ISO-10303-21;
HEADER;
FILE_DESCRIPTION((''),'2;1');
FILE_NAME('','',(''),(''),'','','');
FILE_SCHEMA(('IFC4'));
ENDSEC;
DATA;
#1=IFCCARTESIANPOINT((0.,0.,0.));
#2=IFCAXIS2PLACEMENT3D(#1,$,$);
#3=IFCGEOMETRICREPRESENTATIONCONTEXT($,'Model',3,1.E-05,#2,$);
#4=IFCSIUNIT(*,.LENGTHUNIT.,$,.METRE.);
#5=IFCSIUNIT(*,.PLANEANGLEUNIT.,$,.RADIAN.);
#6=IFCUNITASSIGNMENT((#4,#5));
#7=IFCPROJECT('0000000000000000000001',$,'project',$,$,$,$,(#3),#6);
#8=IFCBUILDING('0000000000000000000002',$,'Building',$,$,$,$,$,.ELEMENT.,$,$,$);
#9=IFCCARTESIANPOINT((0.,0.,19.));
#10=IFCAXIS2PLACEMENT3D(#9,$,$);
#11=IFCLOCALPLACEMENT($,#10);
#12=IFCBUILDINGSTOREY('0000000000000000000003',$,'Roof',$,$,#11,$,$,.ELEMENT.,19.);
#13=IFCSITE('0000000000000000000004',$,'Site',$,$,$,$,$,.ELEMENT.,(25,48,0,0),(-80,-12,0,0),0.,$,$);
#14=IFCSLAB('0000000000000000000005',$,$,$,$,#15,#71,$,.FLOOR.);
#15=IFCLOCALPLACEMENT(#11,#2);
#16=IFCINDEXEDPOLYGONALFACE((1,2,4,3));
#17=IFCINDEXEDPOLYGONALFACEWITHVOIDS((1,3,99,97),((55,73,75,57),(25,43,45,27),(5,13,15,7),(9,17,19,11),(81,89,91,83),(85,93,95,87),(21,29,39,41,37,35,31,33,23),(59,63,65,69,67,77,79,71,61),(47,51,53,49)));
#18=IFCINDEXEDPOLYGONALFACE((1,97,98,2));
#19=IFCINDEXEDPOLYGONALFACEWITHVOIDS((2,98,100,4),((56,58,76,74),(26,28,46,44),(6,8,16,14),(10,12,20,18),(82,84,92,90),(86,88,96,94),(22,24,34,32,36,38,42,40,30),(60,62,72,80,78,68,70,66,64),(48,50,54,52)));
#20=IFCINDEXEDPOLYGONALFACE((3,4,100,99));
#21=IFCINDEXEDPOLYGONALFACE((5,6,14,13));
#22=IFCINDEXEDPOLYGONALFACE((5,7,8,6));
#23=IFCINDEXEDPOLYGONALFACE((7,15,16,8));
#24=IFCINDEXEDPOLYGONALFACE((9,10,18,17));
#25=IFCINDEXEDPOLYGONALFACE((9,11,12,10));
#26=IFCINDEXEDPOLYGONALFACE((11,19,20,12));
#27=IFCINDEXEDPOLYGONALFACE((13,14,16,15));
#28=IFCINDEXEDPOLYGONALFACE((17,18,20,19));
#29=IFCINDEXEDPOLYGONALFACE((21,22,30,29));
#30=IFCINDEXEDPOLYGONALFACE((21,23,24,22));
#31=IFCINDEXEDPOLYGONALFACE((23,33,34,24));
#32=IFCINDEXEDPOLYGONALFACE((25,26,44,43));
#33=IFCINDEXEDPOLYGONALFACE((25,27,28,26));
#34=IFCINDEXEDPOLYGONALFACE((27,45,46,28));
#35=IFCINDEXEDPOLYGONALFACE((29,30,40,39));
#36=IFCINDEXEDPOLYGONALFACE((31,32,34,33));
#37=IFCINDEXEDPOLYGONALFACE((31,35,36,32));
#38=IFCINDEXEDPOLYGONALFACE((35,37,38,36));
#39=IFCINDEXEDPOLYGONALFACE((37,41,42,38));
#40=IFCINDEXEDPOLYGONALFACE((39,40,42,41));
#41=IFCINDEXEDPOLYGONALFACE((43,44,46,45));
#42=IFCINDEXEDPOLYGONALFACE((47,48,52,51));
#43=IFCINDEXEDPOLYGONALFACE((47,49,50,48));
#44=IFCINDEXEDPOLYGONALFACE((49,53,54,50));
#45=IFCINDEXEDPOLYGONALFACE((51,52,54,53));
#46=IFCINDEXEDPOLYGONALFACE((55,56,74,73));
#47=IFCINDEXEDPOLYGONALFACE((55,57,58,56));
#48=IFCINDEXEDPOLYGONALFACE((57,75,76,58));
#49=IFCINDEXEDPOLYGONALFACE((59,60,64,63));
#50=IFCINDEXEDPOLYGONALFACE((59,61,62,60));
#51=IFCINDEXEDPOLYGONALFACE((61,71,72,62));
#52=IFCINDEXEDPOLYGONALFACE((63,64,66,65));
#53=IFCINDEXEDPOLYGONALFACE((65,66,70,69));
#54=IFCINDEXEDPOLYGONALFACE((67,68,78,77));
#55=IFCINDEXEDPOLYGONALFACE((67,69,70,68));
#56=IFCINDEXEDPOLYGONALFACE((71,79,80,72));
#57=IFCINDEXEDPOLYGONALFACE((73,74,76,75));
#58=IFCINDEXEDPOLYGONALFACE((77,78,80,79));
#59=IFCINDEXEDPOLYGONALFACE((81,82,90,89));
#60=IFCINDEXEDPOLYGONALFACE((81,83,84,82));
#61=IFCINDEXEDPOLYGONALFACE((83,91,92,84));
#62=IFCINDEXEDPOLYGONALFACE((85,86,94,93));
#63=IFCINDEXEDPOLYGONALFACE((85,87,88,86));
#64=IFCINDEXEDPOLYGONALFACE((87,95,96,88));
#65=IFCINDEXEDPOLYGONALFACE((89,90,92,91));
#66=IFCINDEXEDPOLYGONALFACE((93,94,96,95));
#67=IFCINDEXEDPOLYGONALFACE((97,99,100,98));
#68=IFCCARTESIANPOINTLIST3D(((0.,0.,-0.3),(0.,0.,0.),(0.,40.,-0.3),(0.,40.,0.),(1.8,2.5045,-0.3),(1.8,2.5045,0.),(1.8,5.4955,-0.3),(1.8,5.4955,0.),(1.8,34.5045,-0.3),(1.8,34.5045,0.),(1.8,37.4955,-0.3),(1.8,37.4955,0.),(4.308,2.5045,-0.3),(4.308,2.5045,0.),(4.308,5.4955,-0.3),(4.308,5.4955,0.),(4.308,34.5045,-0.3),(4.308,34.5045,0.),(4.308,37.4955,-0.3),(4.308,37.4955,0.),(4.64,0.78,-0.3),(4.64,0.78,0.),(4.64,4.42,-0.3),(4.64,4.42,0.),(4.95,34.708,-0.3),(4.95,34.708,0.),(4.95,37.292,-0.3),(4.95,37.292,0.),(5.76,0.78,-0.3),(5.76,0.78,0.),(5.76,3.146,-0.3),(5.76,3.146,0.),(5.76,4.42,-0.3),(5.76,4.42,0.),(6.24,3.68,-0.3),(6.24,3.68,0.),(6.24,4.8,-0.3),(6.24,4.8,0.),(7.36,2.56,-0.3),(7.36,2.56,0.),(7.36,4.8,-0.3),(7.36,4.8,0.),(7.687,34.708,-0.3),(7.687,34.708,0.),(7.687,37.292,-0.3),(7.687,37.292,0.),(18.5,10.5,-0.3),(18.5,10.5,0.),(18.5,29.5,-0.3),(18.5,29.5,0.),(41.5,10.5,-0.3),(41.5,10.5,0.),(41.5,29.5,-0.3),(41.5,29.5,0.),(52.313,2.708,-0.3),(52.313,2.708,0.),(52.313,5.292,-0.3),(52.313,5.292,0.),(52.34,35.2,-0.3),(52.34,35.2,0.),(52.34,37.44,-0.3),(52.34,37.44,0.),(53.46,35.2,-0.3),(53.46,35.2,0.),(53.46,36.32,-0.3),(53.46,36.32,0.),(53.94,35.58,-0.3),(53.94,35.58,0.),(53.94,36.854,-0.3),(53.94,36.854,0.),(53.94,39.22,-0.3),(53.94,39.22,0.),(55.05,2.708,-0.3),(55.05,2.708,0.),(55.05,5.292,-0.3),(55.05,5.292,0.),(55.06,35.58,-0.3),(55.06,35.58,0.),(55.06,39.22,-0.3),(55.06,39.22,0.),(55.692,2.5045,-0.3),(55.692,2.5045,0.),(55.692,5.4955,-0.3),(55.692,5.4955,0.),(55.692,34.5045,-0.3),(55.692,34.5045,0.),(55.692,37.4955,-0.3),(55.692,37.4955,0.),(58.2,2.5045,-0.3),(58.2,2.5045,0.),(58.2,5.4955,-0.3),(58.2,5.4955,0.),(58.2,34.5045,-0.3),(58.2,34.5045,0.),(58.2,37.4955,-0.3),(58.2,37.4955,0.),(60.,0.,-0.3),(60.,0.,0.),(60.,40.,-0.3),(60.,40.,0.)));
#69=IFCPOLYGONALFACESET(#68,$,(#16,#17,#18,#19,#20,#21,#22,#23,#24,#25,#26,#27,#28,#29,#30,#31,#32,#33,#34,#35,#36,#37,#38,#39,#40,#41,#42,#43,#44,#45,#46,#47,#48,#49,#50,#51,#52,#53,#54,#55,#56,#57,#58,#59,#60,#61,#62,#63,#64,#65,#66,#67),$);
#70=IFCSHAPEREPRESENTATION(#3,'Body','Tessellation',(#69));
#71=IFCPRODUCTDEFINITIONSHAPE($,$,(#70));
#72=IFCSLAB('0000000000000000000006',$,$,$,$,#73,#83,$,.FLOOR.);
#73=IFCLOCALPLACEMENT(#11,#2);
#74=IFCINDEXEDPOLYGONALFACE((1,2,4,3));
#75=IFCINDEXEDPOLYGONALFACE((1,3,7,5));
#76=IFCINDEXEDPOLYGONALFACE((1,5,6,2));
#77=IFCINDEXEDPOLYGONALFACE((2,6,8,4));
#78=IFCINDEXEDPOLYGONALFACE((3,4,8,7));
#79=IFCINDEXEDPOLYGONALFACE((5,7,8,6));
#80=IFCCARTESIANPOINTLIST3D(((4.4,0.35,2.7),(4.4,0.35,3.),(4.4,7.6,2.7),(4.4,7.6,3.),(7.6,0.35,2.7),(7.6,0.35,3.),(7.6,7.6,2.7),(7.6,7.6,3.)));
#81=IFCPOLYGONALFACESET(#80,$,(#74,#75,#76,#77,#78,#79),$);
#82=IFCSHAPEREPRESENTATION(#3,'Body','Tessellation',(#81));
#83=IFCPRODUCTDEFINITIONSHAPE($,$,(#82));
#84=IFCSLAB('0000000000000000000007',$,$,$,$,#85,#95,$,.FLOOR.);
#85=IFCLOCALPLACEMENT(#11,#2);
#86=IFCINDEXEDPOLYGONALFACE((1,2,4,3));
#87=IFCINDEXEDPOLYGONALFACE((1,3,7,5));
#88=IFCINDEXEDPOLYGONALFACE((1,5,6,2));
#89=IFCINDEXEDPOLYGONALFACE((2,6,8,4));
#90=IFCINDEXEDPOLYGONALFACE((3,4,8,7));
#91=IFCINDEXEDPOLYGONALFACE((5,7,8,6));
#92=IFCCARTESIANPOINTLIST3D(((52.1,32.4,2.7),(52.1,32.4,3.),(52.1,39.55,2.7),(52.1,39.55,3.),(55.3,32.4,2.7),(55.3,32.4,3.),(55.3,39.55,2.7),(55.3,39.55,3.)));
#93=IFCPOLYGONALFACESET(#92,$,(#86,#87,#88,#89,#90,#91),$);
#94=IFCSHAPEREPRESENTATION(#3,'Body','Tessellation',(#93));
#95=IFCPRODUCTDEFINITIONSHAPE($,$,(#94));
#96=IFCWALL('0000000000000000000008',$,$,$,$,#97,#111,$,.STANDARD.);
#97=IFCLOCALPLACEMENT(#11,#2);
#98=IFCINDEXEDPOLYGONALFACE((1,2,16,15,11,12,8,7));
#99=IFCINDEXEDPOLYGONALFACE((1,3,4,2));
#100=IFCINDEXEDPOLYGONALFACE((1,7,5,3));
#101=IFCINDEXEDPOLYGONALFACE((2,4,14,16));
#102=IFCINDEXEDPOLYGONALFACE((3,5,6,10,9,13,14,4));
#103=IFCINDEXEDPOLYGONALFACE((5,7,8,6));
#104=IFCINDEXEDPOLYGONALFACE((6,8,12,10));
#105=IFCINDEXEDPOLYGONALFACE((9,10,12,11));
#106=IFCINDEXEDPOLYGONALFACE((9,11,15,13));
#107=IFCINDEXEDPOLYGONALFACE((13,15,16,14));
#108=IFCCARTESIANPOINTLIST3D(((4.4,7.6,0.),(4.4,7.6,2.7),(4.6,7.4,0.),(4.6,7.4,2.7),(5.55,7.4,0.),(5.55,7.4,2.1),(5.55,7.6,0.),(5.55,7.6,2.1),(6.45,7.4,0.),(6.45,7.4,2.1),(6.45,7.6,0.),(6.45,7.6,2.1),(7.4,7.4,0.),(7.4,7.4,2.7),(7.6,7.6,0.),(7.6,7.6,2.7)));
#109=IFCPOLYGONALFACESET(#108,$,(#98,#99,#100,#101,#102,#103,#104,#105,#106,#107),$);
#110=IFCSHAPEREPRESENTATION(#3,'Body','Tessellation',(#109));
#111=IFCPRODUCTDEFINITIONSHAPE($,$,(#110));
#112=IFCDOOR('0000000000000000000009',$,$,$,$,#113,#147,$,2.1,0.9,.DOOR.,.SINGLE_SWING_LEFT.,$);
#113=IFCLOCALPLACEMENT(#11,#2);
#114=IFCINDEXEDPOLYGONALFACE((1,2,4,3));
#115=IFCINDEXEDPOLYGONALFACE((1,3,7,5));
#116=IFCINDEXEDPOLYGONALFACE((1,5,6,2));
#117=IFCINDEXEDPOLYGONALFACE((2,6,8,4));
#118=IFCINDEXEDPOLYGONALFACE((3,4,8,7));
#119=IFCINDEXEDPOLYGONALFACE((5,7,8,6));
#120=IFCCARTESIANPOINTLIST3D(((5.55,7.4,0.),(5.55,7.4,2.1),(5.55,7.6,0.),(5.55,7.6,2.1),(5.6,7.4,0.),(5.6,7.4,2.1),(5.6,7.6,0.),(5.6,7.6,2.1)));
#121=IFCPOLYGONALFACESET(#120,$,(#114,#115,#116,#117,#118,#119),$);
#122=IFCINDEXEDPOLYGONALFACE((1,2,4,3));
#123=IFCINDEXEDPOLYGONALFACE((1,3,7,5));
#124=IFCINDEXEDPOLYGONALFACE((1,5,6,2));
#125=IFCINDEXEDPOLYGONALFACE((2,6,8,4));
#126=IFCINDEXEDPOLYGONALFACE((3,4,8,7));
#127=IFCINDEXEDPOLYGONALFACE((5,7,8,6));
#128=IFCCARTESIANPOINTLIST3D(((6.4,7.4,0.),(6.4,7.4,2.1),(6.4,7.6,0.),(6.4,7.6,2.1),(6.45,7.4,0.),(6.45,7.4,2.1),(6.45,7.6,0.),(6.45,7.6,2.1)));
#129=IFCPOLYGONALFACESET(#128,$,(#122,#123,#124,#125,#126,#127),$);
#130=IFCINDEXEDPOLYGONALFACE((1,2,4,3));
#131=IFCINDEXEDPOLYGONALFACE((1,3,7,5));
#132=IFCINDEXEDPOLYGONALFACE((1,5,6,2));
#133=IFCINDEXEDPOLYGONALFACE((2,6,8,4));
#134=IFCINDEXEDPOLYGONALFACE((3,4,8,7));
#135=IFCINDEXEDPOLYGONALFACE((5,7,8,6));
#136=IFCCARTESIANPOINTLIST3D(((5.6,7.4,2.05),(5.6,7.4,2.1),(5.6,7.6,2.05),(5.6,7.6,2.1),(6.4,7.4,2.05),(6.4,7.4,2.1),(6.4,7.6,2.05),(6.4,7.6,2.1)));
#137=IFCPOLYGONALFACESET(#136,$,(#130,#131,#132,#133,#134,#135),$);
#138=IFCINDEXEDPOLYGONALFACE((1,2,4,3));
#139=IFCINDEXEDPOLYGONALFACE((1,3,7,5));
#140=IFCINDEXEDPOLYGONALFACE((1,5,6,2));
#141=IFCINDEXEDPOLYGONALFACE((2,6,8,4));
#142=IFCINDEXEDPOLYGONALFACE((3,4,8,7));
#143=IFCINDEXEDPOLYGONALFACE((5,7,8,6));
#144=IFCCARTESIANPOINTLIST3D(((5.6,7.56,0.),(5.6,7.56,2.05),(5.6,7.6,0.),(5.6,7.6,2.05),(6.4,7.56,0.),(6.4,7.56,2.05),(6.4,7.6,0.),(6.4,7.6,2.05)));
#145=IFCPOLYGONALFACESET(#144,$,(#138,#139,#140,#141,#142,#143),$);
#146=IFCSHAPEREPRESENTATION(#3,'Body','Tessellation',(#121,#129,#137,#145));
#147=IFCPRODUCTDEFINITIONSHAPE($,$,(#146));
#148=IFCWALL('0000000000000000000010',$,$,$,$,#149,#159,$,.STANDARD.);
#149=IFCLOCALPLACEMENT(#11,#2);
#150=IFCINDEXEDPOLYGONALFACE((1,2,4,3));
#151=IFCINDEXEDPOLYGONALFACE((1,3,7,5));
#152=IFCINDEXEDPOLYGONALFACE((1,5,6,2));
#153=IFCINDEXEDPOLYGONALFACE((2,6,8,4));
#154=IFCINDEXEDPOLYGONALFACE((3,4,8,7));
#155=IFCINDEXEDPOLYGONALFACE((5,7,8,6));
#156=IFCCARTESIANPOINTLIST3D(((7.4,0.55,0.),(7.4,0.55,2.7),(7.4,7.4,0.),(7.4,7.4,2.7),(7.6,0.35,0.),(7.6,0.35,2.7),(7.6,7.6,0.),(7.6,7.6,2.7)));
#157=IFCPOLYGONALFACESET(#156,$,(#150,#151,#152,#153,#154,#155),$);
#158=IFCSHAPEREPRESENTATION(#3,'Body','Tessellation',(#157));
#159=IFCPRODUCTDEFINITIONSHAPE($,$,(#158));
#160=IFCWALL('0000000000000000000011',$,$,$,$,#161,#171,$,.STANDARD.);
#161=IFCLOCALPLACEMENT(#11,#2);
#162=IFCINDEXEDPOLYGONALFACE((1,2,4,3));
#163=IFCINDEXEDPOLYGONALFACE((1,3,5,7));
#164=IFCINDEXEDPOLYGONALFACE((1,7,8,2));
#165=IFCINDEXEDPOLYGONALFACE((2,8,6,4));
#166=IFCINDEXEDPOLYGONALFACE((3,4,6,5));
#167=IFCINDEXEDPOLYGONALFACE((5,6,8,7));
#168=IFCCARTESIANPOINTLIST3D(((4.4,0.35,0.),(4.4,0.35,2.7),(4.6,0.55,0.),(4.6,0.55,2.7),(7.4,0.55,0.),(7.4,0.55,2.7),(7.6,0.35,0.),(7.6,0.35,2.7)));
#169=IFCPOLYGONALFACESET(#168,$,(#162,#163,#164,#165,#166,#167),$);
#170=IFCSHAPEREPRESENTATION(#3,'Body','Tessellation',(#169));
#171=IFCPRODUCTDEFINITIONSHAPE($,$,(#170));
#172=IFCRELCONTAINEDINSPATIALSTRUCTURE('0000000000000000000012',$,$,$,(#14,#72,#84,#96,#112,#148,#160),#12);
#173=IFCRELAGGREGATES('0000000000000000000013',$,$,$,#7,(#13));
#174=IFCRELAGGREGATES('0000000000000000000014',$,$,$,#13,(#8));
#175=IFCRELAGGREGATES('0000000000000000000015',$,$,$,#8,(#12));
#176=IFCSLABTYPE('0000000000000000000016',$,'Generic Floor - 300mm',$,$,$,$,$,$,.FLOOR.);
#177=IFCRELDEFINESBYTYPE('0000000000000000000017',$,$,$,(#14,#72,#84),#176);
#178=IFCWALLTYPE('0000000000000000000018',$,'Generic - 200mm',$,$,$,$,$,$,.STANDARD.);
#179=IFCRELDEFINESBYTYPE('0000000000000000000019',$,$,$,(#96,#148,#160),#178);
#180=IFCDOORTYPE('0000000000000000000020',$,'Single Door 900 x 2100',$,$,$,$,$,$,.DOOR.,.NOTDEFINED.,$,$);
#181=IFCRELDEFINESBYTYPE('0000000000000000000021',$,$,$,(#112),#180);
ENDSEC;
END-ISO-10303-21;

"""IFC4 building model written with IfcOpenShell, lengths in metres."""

from ifc_helpers import new_model, si_unit, frame, frame_2d, origin, origin_with_axes, origin_2d, place, context, project, spatial, polyline, rectangle, outline, extrude, type_object, element, fill, save


model = new_model("IFC4")

# Units and contexts
model_context = context("Model", 3, precision=1e-05, world=origin())
ifc_project = project(units=[si_unit("LENGTHUNIT", "METRE"), si_unit("PLANEANGLEUNIT", "RADIAN")], contexts=[model_context])

# Site, building, storey
site = spatial("IfcSite", under=ifc_project, Name="Site", CompositionType="ELEMENT", RefLatitude=(25, 48, 0, 0), RefLongitude=(-80, -12, 0, 0), RefElevation=0.0)
building = spatial("IfcBuilding", under=site, Name="Building", CompositionType="ELEMENT")
storey_placement = place(None, frame((0.0, 0.0, 19.0)))
storey = spatial("IfcBuildingStorey", under=building, at=storey_placement, Name="Roof", CompositionType="ELEMENT", Elevation=19.0)

# Slab, openings
slab_type = type_object("IfcSlabType", Name="Generic Floor - 300mm", PredefinedType="FLOOR")
slab_1_placement = place(None, frame((0.0, 0.0, 19.0)))
slab_1 = element("IfcSlab", 1, at=slab_1_placement, inside=storey, type_object=slab_type, PredefinedType="FLOOR", context=model_context, shape_type="SweptSolid", body=[
    extrude(outline(polyline([(0.0, 0.0), (60.0, 0.0), (60.0, 40.0), (0.0, 40.0), (0.0, 0.0)])), origin(), (0.0, 0.0, -1.0), 0.3),
])
opening_1_placement = place(None, frame((0.0, 0.0, 19.001)))
element("IfcOpeningElement", 2, at=opening_1_placement, cuts=slab_1, PredefinedType="OPENING", context=model_context, shape_type="SweptSolid", body=[
    extrude(outline(polyline([(4.64, 0.78), (5.76, 0.78), (7.36, 2.56), (7.36, 4.8), (6.24, 4.8), (6.24, 3.68), (5.76, 3.146), (5.76, 4.42), (4.64, 4.42), (4.64, 0.78)])), origin(), (0.0, 0.0, -1.0), 0.302),
])
opening_2_placement = place(None, frame((0.0, 0.0, 19.001)))
element("IfcOpeningElement", 3, at=opening_2_placement, cuts=slab_1, PredefinedType="OPENING", context=model_context, shape_type="SweptSolid", body=[
    extrude(outline(polyline([(52.34, 35.2), (53.46, 35.2), (53.46, 36.32), (53.94, 36.854), (53.94, 35.58), (55.06, 35.58), (55.06, 39.22), (53.94, 39.22), (52.34, 37.44), (52.34, 35.2)])), origin(), (0.0, 0.0, -1.0), 0.302),
])
opening_3_placement = place(None, frame((0.0, 0.0, 19.001)))
element("IfcOpeningElement", 4, at=opening_3_placement, cuts=slab_1, PredefinedType="OPENING", context=model_context, shape_type="SweptSolid", body=[
    extrude(outline(polyline([(1.8, 5.4955), (1.8, 2.5045), (4.308, 2.5045), (4.308, 5.4955), (1.8, 5.4955)])), origin(), (0.0, 0.0, -1.0), 0.302),
])
opening_4_placement = place(None, frame((0.0, 0.0, 19.001)))
element("IfcOpeningElement", 5, at=opening_4_placement, cuts=slab_1, PredefinedType="OPENING", context=model_context, shape_type="SweptSolid", body=[
    extrude(outline(polyline([(58.2, 2.5045), (58.2, 5.4955), (55.692, 5.4955), (55.692, 2.5045), (58.2, 2.5045)])), origin(), (0.0, 0.0, -1.0), 0.302),
])
opening_5_placement = place(None, frame((0.0, 0.0, 19.001)))
element("IfcOpeningElement", 6, at=opening_5_placement, cuts=slab_1, PredefinedType="OPENING", context=model_context, shape_type="SweptSolid", body=[
    extrude(outline(polyline([(55.05, 2.708), (55.05, 5.292), (52.313, 5.292), (52.313, 2.708), (55.05, 2.708)])), origin(), (0.0, 0.0, -1.0), 0.302),
])
opening_6_placement = place(None, frame((0.0, 0.0, 19.001)))
element("IfcOpeningElement", 7, at=opening_6_placement, cuts=slab_1, PredefinedType="OPENING", context=model_context, shape_type="SweptSolid", body=[
    extrude(outline(polyline([(1.8, 37.4955), (1.8, 34.5045), (4.308, 34.5045), (4.308, 37.4955), (1.8, 37.4955)])), origin(), (0.0, 0.0, -1.0), 0.302),
])
opening_7_placement = place(None, frame((0.0, 0.0, 19.001)))
element("IfcOpeningElement", 8, at=opening_7_placement, cuts=slab_1, PredefinedType="OPENING", context=model_context, shape_type="SweptSolid", body=[
    extrude(outline(polyline([(4.95, 37.292), (4.95, 34.708), (7.687, 34.708), (7.687, 37.292), (4.95, 37.292)])), origin(), (0.0, 0.0, -1.0), 0.302),
])
opening_8_placement = place(None, frame((0.0, 0.0, 19.001)))
element("IfcOpeningElement", 9, at=opening_8_placement, cuts=slab_1, PredefinedType="OPENING", context=model_context, shape_type="SweptSolid", body=[
    extrude(outline(polyline([(58.2, 34.5045), (58.2, 37.4955), (55.692, 37.4955), (55.692, 34.5045), (58.2, 34.5045)])), origin(), (0.0, 0.0, -1.0), 0.302),
])
opening_9_placement = place(None, frame((0.0, 0.0, 19.001)))
element("IfcOpeningElement", 10, at=opening_9_placement, cuts=slab_1, PredefinedType="OPENING", context=model_context, shape_type="SweptSolid", body=[
    extrude(outline(polyline([(18.5, 10.5), (41.5, 10.5), (41.5, 29.5), (18.5, 29.5), (18.5, 10.5)])), origin(), (0.0, 0.0, -1.0), 0.302),
])

# Slabs
slab_2_placement = place(None, frame((0.0, 0.0, 22.0)))
element("IfcSlab", 11, at=slab_2_placement, inside=storey, type_object=slab_type, PredefinedType="FLOOR", context=model_context, shape_type="SweptSolid", body=[
    extrude(outline(polyline([(4.4, 0.35), (7.6, 0.35), (7.6, 7.6), (4.4, 7.6), (4.4, 0.35)])), origin(), (0.0, 0.0, -1.0), 0.3),
])
slab_3_placement = place(None, frame((0.0, 0.0, 22.0)))
element("IfcSlab", 12, at=slab_3_placement, inside=storey, type_object=slab_type, PredefinedType="FLOOR", context=model_context, shape_type="SweptSolid", body=[
    extrude(outline(polyline([(52.1, 32.4), (55.3, 32.4), (55.3, 39.55), (52.1, 39.55), (52.1, 32.4)])), origin(), (0.0, 0.0, -1.0), 0.3),
])

# Wall, opening, door
wall_type = type_object("IfcWallType", Name="Generic - 200mm", PredefinedType="STANDARD")
wall_1_placement = place(None, frame((4.5, 7.5, 19.0), z_axis=(0.0, 0.0, 1.0), x_axis=(1.0, 0.0, 0.0)))
wall_1 = element("IfcWall", 13, at=wall_1_placement, inside=storey, type_object=wall_type, PredefinedType="STANDARD", context=model_context, shape_type="SweptSolid", body=[
    extrude(outline(polyline([(0.1, -0.1), (2.9, -0.1), (3.1, 0.1), (-0.1, 0.1), (0.1, -0.1)])), origin(), (0.0, 0.0, 1.0), 2.7),
])
opening_10_placement = place(wall_1_placement, frame((1.5, 0.0, 0.0), z_axis=(0.0, 0.0, 1.0), x_axis=(1.0, 0.0, 0.0)))
opening_10 = element("IfcOpeningElement", 14, at=opening_10_placement, cuts=wall_1, PredefinedType="OPENING", context=model_context, shape_type="SweptSolid", body=[
    extrude(rectangle(XDim=0.9, YDim=0.202, at=origin_2d()), origin(), (0.0, 0.0, 1.0), 2.1),
])
door_type = type_object("IfcDoorType", Name="Single Door 900 x 2100", OperationType="NOTDEFINED", PredefinedType="DOOR")
door_1_placement = place(opening_10_placement, origin_with_axes())
door_1 = element("IfcDoor", 15, at=door_1_placement, inside=storey, type_object=door_type, OperationType="SINGLE_SWING_LEFT", OverallHeight=2.1, OverallWidth=0.9, PredefinedType="DOOR", context=model_context, shape_type="SweptSolid", body=[
    extrude(rectangle(XDim=0.05, YDim=0.2, at=frame_2d((-0.425, 0.0))), origin(), (0.0, 0.0, 1.0), 2.1),
    extrude(rectangle(XDim=0.05, YDim=0.2, at=frame_2d((0.425, 0.0))), origin(), (0.0, 0.0, 1.0), 2.1),
    extrude(rectangle(XDim=0.8, YDim=0.2, at=origin_2d()), frame((0.0, 0.0, 2.05)), (0.0, 0.0, 1.0), 0.05),
    extrude(rectangle(XDim=0.8, YDim=0.04, at=frame_2d((0.0, 0.08))), origin(), (0.0, 0.0, 1.0), 2.05),
])
fill(opening_10, door_1)

# Walls
wall_2_placement = place(None, frame((7.5, 7.5, 19.0), z_axis=(0.0, 0.0, 1.0), x_axis=(0.0, -1.0, 0.0)))
element("IfcWall", 16, at=wall_2_placement, inside=storey, type_object=wall_type, PredefinedType="STANDARD", context=model_context, shape_type="SweptSolid", body=[
    extrude(outline(polyline([(0.1, -0.1), (6.95, -0.1), (7.15, 0.1), (-0.1, 0.1), (0.1, -0.1)])), origin(), (0.0, 0.0, 1.0), 2.7),
])
wall_3_placement = place(None, frame((7.5, 0.45, 19.0), z_axis=(0.0, 0.0, 1.0), x_axis=(-1.0, 0.0, 0.0)))
element("IfcWall", 17, at=wall_3_placement, inside=storey, type_object=wall_type, PredefinedType="STANDARD", context=model_context, shape_type="SweptSolid", body=[
    extrude(outline(polyline([(0.1, -0.1), (2.9, -0.1), (3.1, 0.1), (-0.1, 0.1), (0.1, -0.1)])), origin(), (0.0, 0.0, 1.0), 2.7),
])

save(model, "model.ifc")
